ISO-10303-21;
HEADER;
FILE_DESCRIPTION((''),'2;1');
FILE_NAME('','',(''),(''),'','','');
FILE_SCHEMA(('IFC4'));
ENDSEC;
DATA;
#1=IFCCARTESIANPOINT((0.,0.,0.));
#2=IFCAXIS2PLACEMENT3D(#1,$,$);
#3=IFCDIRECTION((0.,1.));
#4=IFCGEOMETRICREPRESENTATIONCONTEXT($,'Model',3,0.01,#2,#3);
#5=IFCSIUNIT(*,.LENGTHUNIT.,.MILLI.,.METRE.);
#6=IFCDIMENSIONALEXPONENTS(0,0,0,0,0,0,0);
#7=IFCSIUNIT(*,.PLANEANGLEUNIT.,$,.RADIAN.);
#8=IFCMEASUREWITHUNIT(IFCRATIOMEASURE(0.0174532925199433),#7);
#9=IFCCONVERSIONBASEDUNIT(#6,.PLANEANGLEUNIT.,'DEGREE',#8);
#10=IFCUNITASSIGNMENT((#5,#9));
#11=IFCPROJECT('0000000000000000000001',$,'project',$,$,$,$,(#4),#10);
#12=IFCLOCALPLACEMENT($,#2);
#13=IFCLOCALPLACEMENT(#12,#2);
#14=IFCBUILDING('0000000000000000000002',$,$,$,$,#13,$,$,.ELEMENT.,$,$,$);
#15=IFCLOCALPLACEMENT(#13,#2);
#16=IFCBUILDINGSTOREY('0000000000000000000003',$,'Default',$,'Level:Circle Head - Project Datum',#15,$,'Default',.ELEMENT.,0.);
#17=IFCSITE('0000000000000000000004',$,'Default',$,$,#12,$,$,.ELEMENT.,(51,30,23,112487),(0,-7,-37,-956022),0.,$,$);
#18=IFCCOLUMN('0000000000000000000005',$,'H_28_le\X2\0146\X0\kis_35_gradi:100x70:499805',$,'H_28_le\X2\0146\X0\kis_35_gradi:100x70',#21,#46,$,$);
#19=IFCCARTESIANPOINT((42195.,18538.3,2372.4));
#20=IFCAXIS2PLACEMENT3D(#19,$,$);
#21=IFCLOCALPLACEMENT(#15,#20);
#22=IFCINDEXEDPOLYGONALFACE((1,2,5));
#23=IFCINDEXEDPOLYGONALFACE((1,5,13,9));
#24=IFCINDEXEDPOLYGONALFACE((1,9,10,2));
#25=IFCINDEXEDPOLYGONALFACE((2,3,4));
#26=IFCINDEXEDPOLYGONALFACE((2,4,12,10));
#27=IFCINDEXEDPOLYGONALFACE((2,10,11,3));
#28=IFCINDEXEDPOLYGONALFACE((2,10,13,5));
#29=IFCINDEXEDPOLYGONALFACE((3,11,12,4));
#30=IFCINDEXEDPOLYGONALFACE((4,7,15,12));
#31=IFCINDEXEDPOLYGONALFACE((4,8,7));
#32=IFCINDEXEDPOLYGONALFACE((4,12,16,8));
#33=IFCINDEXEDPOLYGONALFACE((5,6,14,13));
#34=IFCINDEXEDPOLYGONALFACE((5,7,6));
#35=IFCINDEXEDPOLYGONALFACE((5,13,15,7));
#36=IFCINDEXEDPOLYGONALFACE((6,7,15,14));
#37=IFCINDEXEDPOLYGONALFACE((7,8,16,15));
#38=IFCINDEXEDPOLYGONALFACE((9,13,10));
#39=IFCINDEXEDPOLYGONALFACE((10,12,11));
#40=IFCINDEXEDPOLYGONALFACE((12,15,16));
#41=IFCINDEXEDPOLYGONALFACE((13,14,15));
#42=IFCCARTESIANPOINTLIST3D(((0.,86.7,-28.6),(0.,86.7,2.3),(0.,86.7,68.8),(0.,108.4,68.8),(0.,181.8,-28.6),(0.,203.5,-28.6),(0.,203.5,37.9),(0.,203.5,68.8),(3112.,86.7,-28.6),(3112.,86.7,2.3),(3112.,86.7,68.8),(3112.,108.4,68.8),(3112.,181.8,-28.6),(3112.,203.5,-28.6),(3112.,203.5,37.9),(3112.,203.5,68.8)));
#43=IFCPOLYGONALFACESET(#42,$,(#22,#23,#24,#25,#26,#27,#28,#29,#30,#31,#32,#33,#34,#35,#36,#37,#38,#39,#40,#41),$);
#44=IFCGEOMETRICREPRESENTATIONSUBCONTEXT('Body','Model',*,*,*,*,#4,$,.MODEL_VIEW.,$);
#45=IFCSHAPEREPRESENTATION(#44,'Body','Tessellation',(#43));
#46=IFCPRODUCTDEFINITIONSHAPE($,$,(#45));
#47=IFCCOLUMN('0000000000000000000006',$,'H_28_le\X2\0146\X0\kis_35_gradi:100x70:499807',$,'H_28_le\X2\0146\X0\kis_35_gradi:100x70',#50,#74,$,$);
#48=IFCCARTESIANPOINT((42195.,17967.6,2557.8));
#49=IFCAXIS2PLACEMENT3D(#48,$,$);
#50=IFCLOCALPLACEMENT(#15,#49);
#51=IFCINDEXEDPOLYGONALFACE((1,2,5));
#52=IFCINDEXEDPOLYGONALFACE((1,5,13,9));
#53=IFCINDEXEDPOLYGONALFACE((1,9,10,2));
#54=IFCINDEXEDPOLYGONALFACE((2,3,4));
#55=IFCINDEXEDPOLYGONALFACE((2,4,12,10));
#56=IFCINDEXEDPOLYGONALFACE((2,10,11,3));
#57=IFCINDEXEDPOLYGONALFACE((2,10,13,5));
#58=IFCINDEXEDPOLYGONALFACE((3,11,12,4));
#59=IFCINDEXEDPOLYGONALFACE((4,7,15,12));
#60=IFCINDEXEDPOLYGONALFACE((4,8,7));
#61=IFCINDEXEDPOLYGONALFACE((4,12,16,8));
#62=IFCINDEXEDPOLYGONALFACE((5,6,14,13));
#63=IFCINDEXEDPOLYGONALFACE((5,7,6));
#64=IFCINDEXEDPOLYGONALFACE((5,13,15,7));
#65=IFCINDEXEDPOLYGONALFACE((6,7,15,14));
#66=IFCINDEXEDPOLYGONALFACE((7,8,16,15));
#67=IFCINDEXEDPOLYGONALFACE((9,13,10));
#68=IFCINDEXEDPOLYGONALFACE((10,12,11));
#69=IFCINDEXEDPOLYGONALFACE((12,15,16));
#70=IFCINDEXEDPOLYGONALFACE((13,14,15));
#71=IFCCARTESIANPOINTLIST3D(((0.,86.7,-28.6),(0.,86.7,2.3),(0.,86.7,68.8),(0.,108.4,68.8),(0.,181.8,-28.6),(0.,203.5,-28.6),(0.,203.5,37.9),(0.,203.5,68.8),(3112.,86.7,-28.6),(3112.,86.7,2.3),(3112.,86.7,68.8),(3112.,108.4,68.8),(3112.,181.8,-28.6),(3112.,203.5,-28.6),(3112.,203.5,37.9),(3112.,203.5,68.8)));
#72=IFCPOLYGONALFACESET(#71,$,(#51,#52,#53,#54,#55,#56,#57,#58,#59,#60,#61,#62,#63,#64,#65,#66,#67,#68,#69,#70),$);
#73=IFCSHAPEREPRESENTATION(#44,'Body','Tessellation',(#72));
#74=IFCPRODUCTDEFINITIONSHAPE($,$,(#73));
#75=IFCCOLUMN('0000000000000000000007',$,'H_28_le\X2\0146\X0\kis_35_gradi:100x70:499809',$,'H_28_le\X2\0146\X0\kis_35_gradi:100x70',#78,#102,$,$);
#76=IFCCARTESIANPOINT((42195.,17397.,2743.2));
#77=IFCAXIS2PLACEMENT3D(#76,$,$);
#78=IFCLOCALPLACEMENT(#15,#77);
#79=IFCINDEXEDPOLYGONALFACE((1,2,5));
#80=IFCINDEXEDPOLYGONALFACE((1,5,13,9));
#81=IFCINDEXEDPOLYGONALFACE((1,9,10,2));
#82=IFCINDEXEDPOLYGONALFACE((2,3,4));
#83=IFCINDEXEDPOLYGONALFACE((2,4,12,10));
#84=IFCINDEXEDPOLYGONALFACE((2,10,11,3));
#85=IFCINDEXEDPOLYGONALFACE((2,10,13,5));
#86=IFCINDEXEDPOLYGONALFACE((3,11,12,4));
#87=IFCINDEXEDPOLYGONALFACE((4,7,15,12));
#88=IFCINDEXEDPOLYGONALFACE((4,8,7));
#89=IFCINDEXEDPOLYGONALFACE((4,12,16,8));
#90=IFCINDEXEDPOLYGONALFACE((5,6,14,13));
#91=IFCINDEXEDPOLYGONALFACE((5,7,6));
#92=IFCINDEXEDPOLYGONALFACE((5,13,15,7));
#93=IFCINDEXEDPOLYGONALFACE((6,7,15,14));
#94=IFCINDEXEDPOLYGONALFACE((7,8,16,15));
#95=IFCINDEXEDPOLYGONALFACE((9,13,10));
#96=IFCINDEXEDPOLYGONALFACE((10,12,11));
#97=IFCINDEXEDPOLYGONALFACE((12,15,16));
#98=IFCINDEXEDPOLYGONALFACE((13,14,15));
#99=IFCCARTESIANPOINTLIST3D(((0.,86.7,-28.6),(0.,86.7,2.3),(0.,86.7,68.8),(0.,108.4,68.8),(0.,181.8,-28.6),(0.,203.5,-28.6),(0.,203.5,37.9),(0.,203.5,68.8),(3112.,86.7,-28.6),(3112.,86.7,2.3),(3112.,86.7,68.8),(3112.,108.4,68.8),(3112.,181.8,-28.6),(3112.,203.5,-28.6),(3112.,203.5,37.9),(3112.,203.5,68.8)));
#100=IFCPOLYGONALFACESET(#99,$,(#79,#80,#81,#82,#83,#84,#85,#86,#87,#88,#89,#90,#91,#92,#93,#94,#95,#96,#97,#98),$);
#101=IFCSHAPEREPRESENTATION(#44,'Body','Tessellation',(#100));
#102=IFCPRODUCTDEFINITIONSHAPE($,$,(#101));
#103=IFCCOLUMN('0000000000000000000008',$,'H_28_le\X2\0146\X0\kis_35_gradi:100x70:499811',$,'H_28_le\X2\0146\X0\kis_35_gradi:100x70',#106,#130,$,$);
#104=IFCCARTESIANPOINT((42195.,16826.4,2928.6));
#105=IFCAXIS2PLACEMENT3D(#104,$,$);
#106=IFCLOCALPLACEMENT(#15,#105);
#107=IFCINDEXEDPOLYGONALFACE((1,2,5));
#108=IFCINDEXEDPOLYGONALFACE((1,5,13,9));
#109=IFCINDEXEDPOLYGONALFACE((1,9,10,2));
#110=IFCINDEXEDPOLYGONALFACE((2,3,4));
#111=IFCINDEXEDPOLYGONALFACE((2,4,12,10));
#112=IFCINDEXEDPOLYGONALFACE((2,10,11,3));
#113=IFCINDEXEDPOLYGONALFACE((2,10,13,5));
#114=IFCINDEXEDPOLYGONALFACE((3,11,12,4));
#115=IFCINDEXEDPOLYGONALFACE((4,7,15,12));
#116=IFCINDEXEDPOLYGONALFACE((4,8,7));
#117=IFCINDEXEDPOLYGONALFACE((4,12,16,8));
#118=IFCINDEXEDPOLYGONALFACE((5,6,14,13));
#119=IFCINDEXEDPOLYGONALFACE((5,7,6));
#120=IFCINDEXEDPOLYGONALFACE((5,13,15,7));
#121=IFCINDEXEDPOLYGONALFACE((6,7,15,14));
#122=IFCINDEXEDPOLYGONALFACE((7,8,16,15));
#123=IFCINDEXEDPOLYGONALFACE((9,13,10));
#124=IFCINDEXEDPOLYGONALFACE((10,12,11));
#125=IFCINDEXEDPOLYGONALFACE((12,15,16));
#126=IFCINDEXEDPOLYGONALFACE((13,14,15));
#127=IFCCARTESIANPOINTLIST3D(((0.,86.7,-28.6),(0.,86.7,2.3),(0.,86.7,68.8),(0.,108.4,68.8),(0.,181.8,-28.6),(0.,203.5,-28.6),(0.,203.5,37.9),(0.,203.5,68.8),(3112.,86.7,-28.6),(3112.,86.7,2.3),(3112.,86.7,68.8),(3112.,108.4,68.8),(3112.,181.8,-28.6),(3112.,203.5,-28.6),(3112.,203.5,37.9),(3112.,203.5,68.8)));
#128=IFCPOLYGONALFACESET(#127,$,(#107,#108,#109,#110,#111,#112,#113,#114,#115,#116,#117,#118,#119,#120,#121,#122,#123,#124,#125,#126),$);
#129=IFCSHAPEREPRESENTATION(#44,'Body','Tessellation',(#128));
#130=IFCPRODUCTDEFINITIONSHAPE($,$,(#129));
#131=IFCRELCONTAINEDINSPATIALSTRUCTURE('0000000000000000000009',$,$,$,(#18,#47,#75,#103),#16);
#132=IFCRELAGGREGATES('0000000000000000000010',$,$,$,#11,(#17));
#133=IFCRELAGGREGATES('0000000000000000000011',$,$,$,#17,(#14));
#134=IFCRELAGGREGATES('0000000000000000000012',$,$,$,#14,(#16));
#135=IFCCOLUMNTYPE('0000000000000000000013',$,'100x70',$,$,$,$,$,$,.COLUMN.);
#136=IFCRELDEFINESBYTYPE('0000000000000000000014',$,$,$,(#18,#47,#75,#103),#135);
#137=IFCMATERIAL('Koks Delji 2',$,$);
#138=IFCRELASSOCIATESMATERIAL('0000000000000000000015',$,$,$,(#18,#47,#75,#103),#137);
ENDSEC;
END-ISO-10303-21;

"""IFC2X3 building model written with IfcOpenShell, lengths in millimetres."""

from ifc_helpers import new_model, entity, si_unit, converted_unit, direction, frame, frame_2d, origin, origin_2d_with_axis, place, context, subcontext, project, spatial, rectangle, extrude, boolean, source, transform, mapped, material, type_object, type_shapes, element, save


model = new_model("IFC2X3")

# Units and contexts
model_context = context("Model", 3, precision=0.01, world=origin(), true_north=direction((0.0, 1.0)))
body_context = subcontext(model_context, "Body", "Model", "MODEL_VIEW")
ifc_project = project(units=[si_unit("LENGTHUNIT", "METRE", prefix="MILLI"), converted_unit("PLANEANGLEUNIT", "DEGREE", entity("IfcRatioMeasure", 0.0174532925199433), si_unit("PLANEANGLEUNIT", "RADIAN"), dimensions=[0, 0, 0, 0, 0, 0, 0])], contexts=[model_context])

# Site, building, storey
site_placement = place(None, origin())
site = spatial("IfcSite", under=ifc_project, at=site_placement, Name="Default", CompositionType="ELEMENT", RefLatitude=(51, 30, 23, 112487), RefLongitude=(0, -7, -37, -956022), RefElevation=0.0)
building_placement = place(site_placement, origin())
building = spatial("IfcBuilding", under=site, at=building_placement, CompositionType="ELEMENT")
storey_placement = place(building_placement, origin())
storey = spatial("IfcBuildingStorey", under=building, at=storey_placement, Name="Default", ObjectType="Level:Circle Head - Project Datum", LongName="Default", CompositionType="ELEMENT", Elevation=0.0)

# Columns
ifc_material_1 = material(Name="Koks Delji 2")
column_type_1 = type_object("IfcColumnType", Name="100x70", PredefinedType="COLUMN")
shared_shape_1 = source(origin(), body_context, "Body", "CSG", [
    boolean("DIFFERENCE", extrude(rectangle(XDim=3112.0, YDim=116.7, at=origin_2d_with_axis()), frame((1556.0, 145.1, -28.6)), (0.0, 0.0, 1.0), 97.5), extrude(rectangle(XDim=70.0, YDim=100.0, at=frame_2d((0.0, 0.0), x_axis=(0.0, 1.0))), frame((3112.0, 145.1, 20.1), z_axis=(1.0, 0.0, 0.0), x_axis=(0.0, 0.951057, -0.309017)), (0.0, 0.0, -1.0), 3112.0)),
])
type_shapes(column_type_1, [shared_shape_1])
for number, where, name in (
    (1, (42195.0, 18538.3, 2372.4), "H_28_leņkis_35_gradi:100x70:499805"),
    (2, (42195.0, 17967.6, 2557.8), "H_28_leņkis_35_gradi:100x70:499807"),
    (3, (42195.0, 17397.0, 2743.2), "H_28_leņkis_35_gradi:100x70:499809"),
    (4, (42195.0, 16826.4, 2928.6), "H_28_leņkis_35_gradi:100x70:499811"),
):
    element("IfcColumn", number, at=place(storey_placement, frame(where)), inside=storey, type_object=column_type_1, material=ifc_material_1, Name=name, ObjectType="H_28_leņkis_35_gradi:100x70", context=body_context, shape_type="MappedRepresentation", body=[
        mapped(shared_shape_1, transform((0.0, 0.0, 0.0), scale=1.0)),
    ])

save(model, "model.ifc")
